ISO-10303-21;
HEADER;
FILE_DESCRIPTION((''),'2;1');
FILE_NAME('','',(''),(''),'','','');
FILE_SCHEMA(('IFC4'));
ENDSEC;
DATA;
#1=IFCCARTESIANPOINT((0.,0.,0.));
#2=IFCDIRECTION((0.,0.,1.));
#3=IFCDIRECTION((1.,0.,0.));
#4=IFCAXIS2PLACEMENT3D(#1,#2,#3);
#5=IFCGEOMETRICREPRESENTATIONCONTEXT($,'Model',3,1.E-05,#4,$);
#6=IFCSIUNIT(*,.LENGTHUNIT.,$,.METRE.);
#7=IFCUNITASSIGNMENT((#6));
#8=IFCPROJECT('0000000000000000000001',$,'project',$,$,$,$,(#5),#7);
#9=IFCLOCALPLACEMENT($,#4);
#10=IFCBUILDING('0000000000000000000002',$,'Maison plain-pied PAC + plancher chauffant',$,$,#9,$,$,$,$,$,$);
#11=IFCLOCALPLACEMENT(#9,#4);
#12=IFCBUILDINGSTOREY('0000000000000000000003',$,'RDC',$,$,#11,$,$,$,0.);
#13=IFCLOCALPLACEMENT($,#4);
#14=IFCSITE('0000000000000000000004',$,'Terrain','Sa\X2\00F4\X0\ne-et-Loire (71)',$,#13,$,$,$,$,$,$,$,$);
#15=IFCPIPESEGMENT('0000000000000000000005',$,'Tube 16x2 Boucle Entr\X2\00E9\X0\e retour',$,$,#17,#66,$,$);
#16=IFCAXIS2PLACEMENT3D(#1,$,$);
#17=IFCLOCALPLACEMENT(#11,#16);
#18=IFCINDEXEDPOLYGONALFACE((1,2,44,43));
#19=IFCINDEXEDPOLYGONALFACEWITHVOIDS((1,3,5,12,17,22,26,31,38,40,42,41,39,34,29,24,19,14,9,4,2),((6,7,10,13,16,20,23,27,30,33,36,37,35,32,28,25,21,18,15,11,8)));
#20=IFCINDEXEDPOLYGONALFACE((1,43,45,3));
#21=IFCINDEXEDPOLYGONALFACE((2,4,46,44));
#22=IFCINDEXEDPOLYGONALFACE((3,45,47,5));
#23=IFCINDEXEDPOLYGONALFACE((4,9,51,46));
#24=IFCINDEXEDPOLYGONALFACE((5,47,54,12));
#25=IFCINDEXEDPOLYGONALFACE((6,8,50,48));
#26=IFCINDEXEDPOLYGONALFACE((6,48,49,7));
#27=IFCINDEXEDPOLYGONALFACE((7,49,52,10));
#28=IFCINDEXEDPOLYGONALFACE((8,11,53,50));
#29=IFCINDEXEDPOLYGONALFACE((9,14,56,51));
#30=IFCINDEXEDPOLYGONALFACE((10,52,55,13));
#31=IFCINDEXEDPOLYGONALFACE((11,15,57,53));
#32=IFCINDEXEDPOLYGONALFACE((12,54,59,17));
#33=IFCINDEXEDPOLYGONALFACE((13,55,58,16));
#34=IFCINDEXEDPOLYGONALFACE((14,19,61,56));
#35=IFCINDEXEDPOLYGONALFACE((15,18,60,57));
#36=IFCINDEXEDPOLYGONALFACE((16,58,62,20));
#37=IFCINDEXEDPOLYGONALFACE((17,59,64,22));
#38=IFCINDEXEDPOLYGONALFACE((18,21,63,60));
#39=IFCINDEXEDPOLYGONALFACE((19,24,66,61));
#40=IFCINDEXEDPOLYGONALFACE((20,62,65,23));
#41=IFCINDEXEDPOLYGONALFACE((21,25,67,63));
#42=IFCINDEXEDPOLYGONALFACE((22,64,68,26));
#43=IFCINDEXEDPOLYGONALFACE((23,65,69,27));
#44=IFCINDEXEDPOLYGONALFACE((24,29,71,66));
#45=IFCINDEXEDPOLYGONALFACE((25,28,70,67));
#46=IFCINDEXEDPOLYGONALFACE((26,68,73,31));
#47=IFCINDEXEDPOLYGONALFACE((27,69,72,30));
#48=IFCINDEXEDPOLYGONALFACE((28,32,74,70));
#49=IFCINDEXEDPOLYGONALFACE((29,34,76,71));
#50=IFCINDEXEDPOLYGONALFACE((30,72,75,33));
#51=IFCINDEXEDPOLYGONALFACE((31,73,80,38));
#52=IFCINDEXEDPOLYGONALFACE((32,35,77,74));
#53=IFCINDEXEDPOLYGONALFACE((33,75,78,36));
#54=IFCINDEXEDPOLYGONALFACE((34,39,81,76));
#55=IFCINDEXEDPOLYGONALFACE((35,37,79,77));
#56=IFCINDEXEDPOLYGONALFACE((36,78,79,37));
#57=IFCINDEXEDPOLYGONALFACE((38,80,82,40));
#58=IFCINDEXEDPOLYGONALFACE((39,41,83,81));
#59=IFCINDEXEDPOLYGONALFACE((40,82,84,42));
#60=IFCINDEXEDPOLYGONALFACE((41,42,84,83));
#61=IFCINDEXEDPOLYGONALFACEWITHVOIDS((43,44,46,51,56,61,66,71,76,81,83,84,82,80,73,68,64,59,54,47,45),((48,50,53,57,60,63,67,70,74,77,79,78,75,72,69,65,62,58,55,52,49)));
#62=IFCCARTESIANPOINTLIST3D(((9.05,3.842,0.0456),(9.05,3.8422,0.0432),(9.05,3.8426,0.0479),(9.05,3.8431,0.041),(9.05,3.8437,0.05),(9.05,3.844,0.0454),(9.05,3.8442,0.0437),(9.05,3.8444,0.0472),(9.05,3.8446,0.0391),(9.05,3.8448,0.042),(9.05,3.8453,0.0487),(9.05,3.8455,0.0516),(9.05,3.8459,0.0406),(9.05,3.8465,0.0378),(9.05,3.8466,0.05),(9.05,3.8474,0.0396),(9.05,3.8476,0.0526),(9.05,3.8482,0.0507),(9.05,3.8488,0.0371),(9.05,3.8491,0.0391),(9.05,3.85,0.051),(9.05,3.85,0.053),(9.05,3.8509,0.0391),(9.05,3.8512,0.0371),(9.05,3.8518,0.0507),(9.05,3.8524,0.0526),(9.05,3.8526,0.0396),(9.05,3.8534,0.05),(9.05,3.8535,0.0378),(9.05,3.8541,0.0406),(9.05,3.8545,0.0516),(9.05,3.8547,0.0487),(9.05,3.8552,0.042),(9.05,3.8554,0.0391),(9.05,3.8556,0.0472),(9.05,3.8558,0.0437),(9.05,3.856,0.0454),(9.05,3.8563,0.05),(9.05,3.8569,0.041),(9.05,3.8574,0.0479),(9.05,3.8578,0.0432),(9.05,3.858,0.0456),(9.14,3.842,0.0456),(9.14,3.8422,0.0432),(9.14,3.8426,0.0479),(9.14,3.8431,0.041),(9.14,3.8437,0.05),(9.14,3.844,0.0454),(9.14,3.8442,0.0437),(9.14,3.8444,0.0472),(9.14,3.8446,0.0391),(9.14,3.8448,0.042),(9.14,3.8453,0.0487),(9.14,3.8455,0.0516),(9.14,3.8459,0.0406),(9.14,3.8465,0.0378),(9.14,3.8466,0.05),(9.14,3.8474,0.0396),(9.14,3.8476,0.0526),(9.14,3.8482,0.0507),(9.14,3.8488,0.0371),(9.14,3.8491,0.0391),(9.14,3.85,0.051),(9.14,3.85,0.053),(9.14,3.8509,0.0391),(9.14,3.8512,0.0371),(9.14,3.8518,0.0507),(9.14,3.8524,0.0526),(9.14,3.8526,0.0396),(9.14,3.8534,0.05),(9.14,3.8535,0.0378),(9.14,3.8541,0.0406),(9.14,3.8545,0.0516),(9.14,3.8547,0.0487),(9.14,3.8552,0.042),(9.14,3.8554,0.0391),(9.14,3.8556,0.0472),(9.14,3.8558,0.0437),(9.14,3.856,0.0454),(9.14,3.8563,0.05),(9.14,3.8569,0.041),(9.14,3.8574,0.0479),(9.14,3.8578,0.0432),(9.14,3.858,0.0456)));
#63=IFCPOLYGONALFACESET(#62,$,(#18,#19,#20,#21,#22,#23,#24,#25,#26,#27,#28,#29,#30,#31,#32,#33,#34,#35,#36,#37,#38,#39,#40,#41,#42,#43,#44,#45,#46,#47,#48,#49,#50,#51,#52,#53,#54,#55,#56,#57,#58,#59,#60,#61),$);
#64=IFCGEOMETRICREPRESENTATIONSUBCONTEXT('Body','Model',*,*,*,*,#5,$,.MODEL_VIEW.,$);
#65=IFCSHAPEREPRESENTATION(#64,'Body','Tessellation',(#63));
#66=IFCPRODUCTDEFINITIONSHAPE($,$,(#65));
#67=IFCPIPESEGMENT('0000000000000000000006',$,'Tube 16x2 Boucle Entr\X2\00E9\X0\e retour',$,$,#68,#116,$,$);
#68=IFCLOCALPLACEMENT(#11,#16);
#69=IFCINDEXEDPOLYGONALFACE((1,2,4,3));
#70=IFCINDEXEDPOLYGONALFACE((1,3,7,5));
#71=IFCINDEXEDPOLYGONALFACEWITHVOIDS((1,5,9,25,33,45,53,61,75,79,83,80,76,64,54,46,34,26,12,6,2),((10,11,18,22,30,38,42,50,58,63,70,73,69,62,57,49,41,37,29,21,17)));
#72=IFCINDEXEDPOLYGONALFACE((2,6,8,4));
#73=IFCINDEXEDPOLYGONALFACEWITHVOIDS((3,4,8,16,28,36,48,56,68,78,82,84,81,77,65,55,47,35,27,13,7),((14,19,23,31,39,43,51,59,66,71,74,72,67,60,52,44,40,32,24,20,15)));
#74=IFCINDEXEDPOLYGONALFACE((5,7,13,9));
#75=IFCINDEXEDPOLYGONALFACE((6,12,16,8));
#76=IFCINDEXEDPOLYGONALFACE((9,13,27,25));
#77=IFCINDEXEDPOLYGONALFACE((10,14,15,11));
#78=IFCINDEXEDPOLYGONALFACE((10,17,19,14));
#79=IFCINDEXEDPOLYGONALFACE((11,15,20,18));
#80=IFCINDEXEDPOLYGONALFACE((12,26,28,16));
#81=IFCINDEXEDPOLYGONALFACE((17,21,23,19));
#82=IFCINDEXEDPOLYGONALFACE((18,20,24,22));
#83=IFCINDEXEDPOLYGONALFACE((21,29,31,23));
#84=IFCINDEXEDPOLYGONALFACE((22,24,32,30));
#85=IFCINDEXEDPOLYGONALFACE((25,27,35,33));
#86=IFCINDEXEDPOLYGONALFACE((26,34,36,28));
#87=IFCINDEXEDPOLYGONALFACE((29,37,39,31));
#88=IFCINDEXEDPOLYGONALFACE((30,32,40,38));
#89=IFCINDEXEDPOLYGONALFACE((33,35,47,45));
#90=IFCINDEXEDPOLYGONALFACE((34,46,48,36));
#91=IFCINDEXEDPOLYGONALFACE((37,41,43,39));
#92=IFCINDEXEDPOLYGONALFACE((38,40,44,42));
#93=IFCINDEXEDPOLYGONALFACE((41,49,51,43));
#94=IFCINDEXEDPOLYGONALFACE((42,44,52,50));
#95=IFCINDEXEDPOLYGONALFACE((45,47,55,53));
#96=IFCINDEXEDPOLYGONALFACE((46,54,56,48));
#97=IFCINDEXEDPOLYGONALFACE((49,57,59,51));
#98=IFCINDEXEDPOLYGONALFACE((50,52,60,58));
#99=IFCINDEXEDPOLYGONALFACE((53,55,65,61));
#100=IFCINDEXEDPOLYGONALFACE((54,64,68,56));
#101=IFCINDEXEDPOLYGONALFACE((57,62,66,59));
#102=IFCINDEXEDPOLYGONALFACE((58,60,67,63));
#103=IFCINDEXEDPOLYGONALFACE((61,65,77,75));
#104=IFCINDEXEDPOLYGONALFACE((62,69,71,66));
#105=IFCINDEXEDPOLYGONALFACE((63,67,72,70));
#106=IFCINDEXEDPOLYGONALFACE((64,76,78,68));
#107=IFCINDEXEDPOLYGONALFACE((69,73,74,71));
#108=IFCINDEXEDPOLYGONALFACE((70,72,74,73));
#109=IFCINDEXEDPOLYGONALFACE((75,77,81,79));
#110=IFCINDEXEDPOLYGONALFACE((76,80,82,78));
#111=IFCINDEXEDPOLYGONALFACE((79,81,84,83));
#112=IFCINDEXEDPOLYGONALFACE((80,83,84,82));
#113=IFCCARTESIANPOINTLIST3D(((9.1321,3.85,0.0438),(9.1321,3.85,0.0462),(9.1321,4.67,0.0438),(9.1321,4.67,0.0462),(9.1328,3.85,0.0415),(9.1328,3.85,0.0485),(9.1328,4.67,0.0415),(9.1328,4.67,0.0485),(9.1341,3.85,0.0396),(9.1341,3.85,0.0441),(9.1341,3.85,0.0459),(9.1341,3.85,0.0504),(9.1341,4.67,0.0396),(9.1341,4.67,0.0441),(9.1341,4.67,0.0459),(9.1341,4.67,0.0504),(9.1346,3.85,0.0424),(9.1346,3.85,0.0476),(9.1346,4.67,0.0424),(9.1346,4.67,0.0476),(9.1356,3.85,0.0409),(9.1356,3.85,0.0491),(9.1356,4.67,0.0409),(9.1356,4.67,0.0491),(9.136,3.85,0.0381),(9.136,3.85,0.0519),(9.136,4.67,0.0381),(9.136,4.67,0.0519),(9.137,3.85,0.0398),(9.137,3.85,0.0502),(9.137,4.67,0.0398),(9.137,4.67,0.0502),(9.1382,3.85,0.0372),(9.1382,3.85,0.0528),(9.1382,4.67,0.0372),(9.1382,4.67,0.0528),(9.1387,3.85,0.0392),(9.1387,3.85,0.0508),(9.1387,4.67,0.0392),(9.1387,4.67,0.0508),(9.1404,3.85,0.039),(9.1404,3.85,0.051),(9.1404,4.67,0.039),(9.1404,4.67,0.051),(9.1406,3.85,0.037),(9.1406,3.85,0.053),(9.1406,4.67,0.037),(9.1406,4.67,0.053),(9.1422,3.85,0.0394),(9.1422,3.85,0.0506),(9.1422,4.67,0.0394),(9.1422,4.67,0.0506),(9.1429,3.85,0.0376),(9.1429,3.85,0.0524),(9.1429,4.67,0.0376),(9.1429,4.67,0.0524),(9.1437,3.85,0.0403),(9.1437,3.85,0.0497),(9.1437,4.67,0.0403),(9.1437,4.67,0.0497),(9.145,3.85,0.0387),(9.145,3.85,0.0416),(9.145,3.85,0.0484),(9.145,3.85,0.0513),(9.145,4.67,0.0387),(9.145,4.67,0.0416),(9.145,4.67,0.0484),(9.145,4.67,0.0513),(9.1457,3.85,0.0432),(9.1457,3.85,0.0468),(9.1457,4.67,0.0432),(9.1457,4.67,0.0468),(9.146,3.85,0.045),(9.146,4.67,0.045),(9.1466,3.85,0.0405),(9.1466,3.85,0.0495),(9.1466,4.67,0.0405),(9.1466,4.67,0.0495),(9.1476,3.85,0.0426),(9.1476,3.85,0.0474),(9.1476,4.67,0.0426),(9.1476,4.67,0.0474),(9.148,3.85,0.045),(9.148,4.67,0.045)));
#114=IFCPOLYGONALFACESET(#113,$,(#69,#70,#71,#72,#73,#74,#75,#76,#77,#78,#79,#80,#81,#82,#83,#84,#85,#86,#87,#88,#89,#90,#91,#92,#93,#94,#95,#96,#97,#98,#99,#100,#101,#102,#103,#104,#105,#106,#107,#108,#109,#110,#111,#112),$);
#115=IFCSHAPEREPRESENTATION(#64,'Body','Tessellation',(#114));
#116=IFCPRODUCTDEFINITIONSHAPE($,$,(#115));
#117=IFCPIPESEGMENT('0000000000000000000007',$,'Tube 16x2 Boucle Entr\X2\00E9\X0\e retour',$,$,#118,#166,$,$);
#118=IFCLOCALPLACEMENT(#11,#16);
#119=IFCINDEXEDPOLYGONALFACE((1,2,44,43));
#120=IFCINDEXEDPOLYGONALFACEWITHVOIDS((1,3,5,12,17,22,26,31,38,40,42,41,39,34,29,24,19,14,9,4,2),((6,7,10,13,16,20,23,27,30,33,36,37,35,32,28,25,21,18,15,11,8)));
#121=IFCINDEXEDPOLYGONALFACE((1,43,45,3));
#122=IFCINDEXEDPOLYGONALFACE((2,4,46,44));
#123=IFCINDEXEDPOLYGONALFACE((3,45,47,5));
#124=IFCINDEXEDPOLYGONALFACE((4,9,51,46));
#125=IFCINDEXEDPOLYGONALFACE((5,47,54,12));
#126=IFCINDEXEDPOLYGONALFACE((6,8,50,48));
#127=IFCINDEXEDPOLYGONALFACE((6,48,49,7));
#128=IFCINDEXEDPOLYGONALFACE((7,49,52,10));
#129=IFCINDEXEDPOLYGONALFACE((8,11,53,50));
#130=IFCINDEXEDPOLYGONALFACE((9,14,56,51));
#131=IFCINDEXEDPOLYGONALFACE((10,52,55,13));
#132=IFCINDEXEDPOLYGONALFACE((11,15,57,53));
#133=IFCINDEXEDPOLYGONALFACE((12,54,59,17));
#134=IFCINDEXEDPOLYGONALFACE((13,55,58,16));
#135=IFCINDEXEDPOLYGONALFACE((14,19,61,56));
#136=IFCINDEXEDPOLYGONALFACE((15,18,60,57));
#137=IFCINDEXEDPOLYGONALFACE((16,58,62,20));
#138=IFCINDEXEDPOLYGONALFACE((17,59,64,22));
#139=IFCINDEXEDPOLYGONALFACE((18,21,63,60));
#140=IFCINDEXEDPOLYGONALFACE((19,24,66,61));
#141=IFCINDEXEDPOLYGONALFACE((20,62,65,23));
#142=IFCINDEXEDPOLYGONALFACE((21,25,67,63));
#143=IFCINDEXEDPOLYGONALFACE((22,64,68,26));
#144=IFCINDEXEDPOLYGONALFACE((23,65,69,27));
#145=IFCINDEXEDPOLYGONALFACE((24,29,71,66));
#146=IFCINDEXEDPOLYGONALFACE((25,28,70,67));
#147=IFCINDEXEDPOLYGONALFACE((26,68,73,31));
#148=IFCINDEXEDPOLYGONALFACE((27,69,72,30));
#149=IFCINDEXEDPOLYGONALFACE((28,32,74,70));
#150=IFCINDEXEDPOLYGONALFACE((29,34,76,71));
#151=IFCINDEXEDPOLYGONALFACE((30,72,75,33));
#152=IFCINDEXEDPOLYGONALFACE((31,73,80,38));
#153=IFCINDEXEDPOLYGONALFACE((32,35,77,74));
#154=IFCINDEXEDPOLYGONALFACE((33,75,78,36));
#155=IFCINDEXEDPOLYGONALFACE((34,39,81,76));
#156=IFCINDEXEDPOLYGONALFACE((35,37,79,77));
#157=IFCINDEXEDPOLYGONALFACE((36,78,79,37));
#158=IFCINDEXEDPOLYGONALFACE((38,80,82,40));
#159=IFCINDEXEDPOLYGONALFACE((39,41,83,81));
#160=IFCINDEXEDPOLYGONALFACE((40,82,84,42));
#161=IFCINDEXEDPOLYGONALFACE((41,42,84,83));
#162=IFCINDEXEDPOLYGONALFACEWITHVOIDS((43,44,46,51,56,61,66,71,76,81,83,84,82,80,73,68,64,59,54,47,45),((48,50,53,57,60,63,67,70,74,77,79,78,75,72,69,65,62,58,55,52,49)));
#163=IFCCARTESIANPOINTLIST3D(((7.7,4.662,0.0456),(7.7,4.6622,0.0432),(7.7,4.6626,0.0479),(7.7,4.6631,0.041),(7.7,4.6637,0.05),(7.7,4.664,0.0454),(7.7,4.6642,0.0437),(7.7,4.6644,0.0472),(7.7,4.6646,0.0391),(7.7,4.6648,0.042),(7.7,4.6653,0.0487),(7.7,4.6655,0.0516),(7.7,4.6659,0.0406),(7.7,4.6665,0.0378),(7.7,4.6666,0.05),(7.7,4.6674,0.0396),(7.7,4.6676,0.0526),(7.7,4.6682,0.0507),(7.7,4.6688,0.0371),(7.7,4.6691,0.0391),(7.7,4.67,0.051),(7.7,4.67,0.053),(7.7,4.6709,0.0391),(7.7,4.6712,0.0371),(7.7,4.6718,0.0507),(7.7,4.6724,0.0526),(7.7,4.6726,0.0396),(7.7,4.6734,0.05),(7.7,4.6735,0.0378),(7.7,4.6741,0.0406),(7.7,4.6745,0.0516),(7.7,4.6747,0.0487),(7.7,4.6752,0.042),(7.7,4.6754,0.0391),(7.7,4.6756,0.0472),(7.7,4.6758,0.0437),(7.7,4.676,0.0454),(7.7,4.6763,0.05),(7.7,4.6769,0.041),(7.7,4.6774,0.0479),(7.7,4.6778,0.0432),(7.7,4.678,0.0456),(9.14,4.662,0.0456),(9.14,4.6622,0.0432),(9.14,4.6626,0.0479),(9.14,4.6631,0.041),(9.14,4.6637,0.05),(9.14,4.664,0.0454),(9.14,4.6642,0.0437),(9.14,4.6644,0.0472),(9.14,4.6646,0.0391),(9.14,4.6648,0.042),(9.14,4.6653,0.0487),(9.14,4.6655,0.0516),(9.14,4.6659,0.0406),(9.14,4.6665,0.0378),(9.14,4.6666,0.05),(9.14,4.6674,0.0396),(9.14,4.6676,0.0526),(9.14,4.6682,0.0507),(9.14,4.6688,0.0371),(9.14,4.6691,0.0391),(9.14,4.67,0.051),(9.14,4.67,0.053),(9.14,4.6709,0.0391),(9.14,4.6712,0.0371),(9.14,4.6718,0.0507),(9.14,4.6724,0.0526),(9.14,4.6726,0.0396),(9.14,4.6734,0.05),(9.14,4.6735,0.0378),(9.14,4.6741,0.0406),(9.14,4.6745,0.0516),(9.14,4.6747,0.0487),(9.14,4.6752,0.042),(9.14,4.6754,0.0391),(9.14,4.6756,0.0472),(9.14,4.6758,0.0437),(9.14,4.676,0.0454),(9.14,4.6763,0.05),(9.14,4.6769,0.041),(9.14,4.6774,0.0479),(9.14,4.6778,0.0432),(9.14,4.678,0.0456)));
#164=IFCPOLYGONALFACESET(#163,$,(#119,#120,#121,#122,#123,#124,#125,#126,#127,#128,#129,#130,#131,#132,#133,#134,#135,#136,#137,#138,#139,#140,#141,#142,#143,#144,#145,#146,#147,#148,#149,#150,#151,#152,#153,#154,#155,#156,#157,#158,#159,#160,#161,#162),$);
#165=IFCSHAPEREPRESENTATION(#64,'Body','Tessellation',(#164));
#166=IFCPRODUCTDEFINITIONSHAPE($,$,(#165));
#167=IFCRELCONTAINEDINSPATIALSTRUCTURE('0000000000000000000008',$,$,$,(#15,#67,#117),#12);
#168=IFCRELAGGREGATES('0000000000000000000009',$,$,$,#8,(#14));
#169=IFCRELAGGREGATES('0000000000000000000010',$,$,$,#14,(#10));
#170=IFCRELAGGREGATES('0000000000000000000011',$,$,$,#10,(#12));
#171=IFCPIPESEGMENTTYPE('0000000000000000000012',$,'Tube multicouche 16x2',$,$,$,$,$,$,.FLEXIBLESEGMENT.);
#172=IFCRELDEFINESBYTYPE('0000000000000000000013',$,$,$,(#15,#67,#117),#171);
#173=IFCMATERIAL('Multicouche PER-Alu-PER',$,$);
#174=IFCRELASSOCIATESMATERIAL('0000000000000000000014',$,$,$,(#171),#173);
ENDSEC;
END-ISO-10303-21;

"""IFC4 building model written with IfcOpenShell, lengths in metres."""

from ifc_helpers import new_model, si_unit, frame, origin_with_axes, place, context, subcontext, project, spatial, hollow_circle, extrude, material, type_object, element, save


model = new_model("IFC4")

# Units and contexts
model_context = context("Model", 3, precision=1e-05, world=origin_with_axes())
body_context = subcontext(model_context, "Body", "Model", "MODEL_VIEW")
ifc_project = project(units=[si_unit("LENGTHUNIT", "METRE")], contexts=[model_context])

# Site, building, storey
site_placement = place(None, origin_with_axes())
site = spatial("IfcSite", under=ifc_project, at=site_placement, Name="Terrain", Description="Saône-et-Loire (71)")
building_placement = place(None, origin_with_axes())
building = spatial("IfcBuilding", under=site, at=building_placement, Name="Maison plain-pied PAC + plancher chauffant")
storey_placement = place(building_placement, origin_with_axes())
storey = spatial("IfcBuildingStorey", under=building, at=storey_placement, Name="RDC", Elevation=0.0)

# Pipe segments
ifc_material = material(Name="Multicouche PER-Alu-PER")
pipe_segment_type = type_object("IfcPipeSegmentType", Name="Tube multicouche 16x2", PredefinedType="FLEXIBLESEGMENT", material=ifc_material)
pipe_segment_1_placement = place(storey_placement, frame((9.05, 3.85, 0.045), z_axis=(1.0, 0.0, 0.0), x_axis=(0.0, 0.0, 1.0)))
element("IfcPipeSegment", 1, at=pipe_segment_1_placement, inside=storey, type_object=pipe_segment_type, Name="Tube 16x2 Boucle Entrée retour", context=body_context, shape_type="SweptSolid", body=[
    extrude(hollow_circle(Radius=0.008, WallThickness=0.002), origin_with_axes(), (0.0, 0.0, 1.0), 0.09),
])
pipe_segment_2_placement = place(storey_placement, frame((9.14, 3.85, 0.045), z_axis=(0.0, 1.0, 0.0), x_axis=(1.0, 0.0, 0.0)))
element("IfcPipeSegment", 2, at=pipe_segment_2_placement, inside=storey, type_object=pipe_segment_type, Name="Tube 16x2 Boucle Entrée retour", context=body_context, shape_type="SweptSolid", body=[
    extrude(hollow_circle(Radius=0.008, WallThickness=0.002), origin_with_axes(), (0.0, 0.0, 1.0), 0.82),
])
pipe_segment_3_placement = place(storey_placement, frame((9.14, 4.67, 0.045), z_axis=(-1.0, 0.0, 0.0), x_axis=(0.0, 0.0, 1.0)))
element("IfcPipeSegment", 3, at=pipe_segment_3_placement, inside=storey, type_object=pipe_segment_type, Name="Tube 16x2 Boucle Entrée retour", context=body_context, shape_type="SweptSolid", body=[
    extrude(hollow_circle(Radius=0.008, WallThickness=0.002), origin_with_axes(), (0.0, 0.0, 1.0), 1.44),
])

save(model, "model.ifc")
